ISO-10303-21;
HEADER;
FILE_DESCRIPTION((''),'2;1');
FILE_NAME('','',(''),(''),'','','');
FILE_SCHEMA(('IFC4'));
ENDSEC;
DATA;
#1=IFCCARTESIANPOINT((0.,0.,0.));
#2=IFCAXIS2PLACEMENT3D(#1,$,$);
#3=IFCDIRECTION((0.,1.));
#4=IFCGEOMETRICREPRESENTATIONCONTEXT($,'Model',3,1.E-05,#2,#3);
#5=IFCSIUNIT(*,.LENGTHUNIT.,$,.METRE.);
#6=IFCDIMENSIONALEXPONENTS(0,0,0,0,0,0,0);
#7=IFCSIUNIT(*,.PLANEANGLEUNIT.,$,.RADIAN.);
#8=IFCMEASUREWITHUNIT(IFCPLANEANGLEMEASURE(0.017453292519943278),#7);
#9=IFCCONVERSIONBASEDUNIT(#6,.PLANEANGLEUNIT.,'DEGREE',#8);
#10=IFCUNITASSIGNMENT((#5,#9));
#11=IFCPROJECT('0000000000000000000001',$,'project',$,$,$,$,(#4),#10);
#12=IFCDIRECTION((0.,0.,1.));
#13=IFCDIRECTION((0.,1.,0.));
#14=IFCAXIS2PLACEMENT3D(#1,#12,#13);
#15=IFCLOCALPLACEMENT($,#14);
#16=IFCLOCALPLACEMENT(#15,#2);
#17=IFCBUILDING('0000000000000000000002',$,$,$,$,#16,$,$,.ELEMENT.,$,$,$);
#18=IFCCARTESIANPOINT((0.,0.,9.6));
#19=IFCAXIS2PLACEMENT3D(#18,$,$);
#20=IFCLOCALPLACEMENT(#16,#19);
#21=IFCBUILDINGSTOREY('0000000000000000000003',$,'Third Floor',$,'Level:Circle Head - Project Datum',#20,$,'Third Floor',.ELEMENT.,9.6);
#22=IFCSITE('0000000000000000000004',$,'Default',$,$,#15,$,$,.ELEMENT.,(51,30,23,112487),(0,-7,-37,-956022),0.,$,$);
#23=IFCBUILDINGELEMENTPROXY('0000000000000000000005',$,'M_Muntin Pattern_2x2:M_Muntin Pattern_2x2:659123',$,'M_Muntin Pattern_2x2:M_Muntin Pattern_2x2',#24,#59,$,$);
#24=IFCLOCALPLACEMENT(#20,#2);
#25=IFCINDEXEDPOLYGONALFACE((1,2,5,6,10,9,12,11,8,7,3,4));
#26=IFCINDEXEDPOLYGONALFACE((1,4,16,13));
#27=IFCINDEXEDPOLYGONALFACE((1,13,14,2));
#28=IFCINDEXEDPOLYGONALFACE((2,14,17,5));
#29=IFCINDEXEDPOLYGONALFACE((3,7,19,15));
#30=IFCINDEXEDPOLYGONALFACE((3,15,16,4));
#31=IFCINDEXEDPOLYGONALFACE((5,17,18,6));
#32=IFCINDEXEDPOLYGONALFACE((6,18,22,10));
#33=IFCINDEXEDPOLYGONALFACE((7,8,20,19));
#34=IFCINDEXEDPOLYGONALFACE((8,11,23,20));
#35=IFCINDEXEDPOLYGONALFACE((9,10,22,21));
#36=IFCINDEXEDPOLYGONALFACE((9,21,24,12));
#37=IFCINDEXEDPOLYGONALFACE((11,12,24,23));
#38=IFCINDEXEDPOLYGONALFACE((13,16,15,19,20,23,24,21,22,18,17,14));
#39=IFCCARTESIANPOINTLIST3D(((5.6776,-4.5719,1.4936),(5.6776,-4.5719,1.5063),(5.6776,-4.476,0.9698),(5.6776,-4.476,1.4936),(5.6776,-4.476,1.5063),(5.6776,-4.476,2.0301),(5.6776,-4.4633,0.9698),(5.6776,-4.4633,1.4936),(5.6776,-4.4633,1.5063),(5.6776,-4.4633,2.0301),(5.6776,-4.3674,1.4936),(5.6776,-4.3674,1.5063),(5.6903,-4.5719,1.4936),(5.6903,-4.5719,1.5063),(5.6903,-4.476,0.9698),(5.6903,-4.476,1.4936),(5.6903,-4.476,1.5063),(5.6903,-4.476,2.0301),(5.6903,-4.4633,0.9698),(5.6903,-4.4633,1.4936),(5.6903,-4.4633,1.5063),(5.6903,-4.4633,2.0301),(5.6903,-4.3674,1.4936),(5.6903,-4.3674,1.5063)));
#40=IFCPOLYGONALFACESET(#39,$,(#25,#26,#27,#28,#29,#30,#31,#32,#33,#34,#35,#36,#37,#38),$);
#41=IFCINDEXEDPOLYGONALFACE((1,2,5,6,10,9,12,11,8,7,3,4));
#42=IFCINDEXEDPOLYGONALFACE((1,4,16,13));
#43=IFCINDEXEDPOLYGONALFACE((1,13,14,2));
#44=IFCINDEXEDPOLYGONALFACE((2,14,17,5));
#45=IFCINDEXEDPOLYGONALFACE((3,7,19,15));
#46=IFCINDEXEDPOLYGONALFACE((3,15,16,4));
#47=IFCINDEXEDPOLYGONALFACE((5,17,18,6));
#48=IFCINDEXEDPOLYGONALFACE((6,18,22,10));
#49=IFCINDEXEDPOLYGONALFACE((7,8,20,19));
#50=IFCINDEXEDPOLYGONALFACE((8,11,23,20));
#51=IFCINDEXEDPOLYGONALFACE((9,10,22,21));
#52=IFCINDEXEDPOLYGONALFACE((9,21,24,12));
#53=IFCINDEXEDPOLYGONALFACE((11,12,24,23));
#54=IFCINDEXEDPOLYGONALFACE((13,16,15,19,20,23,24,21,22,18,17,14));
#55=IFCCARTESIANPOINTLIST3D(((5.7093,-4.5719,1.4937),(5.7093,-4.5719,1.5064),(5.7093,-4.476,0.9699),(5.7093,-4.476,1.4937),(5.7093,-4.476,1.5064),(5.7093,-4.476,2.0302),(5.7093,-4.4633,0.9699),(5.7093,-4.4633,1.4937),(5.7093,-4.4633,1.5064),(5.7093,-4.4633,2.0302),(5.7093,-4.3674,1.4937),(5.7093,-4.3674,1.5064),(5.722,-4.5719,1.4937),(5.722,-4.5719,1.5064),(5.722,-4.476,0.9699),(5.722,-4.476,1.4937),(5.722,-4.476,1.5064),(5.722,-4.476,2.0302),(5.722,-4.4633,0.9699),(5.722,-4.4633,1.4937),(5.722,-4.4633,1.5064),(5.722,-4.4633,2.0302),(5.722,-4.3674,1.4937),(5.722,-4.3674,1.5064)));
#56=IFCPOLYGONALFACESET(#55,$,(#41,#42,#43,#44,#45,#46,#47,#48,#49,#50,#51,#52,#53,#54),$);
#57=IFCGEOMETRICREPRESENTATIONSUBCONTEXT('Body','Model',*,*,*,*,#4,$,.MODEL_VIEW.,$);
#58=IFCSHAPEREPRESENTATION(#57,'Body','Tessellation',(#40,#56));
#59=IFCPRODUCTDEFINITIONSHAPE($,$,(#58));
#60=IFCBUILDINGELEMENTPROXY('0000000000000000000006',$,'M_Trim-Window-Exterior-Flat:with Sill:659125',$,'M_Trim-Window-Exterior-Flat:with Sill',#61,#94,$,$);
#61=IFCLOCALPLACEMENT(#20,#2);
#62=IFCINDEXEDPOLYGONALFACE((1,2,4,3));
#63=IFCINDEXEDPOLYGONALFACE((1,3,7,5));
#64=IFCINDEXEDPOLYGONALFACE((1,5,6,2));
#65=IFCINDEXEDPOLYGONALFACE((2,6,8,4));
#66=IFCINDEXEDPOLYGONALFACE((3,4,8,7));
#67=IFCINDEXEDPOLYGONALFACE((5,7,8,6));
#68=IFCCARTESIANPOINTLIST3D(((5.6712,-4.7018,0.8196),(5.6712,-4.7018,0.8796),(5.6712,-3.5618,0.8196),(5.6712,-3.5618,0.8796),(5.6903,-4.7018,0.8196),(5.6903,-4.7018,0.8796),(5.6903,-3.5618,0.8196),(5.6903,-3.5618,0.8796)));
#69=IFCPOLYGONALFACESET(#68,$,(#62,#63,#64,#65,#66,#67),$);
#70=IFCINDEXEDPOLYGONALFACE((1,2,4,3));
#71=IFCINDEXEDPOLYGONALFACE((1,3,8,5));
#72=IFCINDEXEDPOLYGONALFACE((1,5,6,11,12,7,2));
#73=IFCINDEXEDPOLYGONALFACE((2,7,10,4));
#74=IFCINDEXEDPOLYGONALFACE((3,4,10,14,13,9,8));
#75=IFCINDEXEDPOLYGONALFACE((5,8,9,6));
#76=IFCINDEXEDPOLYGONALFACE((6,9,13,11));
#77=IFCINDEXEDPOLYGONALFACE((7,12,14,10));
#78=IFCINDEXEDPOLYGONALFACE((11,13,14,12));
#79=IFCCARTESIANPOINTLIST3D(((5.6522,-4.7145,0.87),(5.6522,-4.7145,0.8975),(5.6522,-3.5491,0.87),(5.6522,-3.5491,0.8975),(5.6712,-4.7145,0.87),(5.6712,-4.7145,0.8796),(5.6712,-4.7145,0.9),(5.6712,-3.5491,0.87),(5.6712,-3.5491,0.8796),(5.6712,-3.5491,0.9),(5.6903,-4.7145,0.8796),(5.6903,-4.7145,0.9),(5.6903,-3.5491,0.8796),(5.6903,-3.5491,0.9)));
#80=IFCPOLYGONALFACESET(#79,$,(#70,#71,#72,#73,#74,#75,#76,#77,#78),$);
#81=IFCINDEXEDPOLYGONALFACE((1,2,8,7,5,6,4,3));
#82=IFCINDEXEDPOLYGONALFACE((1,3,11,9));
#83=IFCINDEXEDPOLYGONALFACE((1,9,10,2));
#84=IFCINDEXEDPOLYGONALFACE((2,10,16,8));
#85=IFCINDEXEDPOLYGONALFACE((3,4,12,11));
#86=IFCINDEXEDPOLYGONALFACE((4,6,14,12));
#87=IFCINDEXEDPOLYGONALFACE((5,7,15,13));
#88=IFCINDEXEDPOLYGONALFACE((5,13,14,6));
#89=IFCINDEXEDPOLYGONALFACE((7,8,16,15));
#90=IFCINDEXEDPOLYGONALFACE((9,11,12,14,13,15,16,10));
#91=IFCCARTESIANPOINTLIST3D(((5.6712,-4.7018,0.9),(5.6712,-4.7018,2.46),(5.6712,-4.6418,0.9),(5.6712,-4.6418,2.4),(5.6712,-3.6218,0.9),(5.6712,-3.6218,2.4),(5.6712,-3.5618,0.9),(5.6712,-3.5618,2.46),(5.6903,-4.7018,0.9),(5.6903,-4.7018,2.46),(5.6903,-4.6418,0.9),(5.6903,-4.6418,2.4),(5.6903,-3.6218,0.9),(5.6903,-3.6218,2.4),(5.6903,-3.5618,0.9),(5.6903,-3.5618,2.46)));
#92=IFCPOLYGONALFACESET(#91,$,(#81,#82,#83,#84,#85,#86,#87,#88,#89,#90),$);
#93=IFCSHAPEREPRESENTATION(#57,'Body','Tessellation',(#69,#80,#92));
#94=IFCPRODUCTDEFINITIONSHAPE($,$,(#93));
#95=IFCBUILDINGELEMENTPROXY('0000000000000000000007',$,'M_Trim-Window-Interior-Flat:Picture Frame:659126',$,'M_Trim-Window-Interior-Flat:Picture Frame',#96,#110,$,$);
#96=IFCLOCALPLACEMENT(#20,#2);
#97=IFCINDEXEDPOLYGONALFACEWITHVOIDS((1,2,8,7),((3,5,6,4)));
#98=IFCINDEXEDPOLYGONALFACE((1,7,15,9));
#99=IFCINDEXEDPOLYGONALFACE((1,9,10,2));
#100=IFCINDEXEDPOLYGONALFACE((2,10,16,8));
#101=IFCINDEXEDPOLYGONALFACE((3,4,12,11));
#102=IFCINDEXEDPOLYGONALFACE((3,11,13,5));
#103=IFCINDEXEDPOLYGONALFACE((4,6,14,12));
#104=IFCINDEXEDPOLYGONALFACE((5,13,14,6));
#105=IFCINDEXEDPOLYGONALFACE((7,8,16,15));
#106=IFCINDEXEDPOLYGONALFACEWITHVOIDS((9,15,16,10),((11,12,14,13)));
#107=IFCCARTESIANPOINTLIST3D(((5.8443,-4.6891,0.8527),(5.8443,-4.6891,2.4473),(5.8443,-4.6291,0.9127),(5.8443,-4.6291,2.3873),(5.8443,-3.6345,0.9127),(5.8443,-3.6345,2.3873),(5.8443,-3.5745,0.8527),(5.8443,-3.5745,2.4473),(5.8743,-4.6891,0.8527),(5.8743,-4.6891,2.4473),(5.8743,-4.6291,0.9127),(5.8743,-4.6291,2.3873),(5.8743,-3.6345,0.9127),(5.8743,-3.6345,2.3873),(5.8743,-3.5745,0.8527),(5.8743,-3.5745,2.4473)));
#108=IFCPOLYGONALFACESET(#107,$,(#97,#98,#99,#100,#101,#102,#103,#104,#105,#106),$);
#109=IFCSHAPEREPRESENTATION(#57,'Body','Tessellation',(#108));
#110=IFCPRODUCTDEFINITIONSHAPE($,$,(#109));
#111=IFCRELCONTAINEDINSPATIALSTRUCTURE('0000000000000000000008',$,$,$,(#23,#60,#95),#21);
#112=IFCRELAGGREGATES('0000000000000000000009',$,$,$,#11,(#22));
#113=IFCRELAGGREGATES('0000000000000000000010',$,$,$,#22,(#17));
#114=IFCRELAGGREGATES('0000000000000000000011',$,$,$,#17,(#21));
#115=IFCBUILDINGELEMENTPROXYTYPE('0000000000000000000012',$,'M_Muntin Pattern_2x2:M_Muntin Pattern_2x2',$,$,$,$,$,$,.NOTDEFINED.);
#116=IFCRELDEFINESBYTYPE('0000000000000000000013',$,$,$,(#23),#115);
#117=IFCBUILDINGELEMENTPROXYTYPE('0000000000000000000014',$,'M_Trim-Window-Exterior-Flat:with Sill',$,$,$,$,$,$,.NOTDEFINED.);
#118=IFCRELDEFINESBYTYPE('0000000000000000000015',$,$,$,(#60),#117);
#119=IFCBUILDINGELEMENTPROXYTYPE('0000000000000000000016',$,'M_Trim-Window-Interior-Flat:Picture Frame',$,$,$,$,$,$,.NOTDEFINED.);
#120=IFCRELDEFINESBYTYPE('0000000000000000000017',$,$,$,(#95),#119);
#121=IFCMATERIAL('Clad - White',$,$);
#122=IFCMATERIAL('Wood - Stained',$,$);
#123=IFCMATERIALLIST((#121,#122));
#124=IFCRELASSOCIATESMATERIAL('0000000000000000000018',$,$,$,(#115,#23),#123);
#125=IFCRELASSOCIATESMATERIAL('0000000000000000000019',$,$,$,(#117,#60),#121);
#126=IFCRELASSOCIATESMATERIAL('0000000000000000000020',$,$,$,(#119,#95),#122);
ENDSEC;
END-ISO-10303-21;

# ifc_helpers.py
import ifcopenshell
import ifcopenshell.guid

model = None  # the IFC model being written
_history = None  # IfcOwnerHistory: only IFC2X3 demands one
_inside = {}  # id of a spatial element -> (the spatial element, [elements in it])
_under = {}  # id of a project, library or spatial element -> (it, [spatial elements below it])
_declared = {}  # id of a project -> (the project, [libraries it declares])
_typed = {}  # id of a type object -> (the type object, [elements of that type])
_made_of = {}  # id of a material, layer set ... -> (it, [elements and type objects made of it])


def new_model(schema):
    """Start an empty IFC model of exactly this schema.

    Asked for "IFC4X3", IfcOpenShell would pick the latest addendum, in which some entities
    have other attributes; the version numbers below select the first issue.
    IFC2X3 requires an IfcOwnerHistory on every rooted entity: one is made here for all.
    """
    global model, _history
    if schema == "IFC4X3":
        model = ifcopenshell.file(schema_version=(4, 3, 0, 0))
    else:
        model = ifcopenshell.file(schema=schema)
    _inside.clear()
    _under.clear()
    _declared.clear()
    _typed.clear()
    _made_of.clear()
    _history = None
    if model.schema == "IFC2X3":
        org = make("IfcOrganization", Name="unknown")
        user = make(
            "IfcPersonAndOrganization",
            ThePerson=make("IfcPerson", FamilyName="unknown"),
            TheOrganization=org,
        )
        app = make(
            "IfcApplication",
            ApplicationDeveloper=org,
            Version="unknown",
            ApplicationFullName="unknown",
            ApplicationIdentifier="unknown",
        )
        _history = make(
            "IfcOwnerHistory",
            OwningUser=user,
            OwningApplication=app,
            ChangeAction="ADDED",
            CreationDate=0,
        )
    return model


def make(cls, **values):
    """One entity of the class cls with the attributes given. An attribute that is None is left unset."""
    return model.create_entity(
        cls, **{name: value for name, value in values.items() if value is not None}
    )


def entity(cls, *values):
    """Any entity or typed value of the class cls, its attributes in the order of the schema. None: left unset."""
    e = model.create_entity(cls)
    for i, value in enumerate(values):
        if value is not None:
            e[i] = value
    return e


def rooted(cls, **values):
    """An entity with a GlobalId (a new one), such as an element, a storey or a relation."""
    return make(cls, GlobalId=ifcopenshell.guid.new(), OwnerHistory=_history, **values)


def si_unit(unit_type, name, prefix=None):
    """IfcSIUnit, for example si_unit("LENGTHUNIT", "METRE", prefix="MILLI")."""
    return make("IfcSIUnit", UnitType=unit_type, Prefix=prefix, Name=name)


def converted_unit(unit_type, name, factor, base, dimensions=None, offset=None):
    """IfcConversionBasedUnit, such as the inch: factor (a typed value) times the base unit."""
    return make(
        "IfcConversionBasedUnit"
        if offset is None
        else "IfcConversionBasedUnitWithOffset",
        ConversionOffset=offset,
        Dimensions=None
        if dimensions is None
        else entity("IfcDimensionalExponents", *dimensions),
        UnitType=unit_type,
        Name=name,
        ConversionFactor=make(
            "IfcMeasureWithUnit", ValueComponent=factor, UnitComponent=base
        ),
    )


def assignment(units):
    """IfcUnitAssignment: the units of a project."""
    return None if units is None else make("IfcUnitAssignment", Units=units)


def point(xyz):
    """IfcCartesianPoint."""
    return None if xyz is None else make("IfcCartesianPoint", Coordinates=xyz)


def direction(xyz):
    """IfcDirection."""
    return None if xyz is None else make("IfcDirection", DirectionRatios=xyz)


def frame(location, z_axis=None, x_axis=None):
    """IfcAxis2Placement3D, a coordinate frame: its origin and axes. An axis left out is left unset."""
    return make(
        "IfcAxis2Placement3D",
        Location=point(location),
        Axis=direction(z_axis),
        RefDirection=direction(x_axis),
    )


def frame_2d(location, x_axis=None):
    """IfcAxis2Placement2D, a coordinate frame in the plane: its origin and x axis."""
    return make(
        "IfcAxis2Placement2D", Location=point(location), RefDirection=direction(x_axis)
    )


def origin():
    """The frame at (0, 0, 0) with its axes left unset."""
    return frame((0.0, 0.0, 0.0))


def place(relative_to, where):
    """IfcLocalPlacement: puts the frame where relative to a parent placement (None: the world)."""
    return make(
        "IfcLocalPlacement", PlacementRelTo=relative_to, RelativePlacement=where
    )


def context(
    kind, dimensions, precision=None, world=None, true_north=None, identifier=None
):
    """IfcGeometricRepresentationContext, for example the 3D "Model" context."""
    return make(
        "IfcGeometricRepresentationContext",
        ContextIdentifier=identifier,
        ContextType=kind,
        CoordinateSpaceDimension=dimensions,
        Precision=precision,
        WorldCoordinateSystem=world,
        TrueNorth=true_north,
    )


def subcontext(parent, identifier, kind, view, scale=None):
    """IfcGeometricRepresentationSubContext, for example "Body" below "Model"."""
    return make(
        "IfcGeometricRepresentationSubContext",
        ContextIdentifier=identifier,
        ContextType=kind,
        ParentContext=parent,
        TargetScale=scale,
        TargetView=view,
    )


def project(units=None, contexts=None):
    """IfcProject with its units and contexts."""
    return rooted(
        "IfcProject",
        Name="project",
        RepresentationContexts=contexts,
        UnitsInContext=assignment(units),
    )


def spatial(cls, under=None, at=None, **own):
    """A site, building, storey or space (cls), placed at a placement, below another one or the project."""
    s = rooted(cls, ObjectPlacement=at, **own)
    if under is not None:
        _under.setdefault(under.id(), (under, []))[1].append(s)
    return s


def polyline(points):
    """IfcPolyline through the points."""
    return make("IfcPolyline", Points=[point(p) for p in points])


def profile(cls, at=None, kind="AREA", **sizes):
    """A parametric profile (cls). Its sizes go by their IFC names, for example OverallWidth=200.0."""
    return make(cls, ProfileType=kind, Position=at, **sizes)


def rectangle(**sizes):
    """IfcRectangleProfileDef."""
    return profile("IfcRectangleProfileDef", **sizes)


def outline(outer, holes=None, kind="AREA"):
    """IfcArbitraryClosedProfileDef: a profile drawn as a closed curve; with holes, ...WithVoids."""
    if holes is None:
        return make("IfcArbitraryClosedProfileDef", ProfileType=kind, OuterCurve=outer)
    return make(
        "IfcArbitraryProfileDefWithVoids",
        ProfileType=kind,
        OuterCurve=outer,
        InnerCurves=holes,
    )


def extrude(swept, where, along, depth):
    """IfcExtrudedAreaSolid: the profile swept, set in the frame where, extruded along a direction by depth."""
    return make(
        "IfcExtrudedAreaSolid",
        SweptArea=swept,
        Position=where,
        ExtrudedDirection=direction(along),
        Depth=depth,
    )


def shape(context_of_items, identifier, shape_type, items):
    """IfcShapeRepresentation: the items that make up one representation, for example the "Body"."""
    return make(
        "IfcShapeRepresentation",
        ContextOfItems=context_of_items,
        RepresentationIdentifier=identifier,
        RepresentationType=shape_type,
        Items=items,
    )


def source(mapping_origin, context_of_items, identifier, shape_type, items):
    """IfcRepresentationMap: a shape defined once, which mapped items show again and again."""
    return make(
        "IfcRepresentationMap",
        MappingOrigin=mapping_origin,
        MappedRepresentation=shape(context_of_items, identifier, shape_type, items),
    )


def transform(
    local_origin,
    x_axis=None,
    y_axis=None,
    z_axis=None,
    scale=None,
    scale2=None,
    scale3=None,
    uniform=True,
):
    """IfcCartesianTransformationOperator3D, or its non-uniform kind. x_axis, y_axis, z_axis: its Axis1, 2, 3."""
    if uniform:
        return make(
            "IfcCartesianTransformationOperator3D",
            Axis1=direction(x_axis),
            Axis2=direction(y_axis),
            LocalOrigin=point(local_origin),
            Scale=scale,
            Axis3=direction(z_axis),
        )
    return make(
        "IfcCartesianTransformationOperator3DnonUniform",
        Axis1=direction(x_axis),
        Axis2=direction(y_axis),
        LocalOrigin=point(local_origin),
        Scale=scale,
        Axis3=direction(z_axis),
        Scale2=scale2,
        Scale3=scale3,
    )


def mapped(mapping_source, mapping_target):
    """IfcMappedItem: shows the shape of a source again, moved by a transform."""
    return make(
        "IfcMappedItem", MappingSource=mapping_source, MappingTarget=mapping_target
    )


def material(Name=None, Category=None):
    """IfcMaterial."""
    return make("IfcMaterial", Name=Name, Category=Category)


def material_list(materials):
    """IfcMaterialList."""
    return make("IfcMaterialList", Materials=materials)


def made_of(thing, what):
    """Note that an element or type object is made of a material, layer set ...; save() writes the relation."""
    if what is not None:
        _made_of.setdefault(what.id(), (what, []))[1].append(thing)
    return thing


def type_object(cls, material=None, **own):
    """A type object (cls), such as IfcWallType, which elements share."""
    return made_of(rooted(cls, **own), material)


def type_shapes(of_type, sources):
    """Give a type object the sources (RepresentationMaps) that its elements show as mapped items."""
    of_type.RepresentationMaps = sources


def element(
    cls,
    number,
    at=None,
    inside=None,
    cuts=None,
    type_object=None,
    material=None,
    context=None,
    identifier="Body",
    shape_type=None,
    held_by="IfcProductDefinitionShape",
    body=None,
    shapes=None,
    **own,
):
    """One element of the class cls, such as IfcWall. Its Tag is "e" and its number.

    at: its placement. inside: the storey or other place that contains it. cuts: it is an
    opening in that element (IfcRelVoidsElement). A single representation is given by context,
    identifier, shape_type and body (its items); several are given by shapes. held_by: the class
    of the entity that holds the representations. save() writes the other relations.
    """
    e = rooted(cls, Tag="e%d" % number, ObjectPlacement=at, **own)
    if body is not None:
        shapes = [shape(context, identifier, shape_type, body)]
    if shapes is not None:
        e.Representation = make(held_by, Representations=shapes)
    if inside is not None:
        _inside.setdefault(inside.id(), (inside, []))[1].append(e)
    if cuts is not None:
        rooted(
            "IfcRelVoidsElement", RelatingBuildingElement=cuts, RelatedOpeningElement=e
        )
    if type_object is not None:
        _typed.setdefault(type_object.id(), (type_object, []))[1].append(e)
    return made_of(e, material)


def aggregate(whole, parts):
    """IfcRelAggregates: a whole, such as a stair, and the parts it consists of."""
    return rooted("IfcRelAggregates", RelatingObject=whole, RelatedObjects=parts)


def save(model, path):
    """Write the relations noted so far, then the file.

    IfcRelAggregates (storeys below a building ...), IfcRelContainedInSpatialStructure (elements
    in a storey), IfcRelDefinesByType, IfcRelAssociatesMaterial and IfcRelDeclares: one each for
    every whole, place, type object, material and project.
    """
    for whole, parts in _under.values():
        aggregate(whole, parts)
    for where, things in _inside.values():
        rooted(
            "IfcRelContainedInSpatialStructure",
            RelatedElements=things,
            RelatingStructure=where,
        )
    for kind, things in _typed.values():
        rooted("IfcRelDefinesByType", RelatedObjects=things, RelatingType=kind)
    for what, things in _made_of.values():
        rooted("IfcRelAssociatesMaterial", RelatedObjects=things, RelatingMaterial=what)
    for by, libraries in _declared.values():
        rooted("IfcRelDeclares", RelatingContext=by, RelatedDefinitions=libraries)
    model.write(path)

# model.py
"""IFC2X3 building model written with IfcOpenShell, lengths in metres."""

from ifc_helpers import new_model, entity, si_unit, converted_unit, direction, frame, frame_2d, origin, place, context, subcontext, project, spatial, polyline, rectangle, outline, extrude, source, transform, mapped, material, material_list, type_object, type_shapes, element, save


model = new_model("IFC2X3")

# Units and contexts
model_context = context("Model", 3, precision=1e-05, world=origin(), true_north=direction((0.0, 1.0)))
body_context = subcontext(model_context, "Body", "Model", "MODEL_VIEW")
ifc_project = project(units=[si_unit("LENGTHUNIT", "METRE"), converted_unit("PLANEANGLEUNIT", "DEGREE", entity("IfcPlaneAngleMeasure", 0.017453292519943278), si_unit("PLANEANGLEUNIT", "RADIAN"), dimensions=[0, 0, 0, 0, 0, 0, 0])], contexts=[model_context])

# Site, building, storey
site_placement = place(None, frame((0.0, 0.0, 0.0), z_axis=(0.0, 0.0, 1.0), x_axis=(0.0, 1.0, 0.0)))
site = spatial("IfcSite", under=ifc_project, at=site_placement, Name="Default", CompositionType="ELEMENT", RefLatitude=(51, 30, 23, 112487), RefLongitude=(0, -7, -37, -956022), RefElevation=0.0)
building_placement = place(site_placement, origin())
building = spatial("IfcBuilding", under=site, at=building_placement, CompositionType="ELEMENT")
storey_placement = place(building_placement, frame((0.0, 0.0, 9.6)))
storey = spatial("IfcBuildingStorey", under=building, at=storey_placement, Name="Third Floor", ObjectType="Level:Circle Head - Project Datum", LongName="Third Floor", CompositionType="ELEMENT", Elevation=9.6)

# Building element proxies
ifc_material_1 = material(Name="Clad - White")
ifc_material_2 = material(Name="Wood - Stained")
ifc_material_list = material_list([ifc_material_1, ifc_material_2])
building_element_proxy_type_1 = type_object("IfcBuildingElementProxyType", Name="M_Muntin Pattern_2x2:M_Muntin Pattern_2x2", PredefinedType="NOTDEFINED", material=ifc_material_list)
shared_shape_1 = source(origin(), body_context, "Body", "SweptSolid", [
    extrude(outline(polyline([(0.0064, -0.0064), (0.5301, -0.0064), (0.5301, 0.0063), (0.0064, 0.0063), (0.0064, 0.1023), (-0.0063, 0.1023), (-0.0063, 0.0063), (-0.5302, 0.0063), (-0.5302, -0.0064), (-0.0063, -0.0064), (-0.0063, -0.1023), (0.0064, -0.1023), (0.0064, -0.0064)])), frame((0.0, 0.0095, 0.5301), z_axis=(0.0, 1.0, 0.0), x_axis=(0.0, 0.0, 1.0)), (0.0, 0.0, 1.0), 0.0127),
    extrude(outline(polyline([(0.0064, -0.0064), (0.5302, -0.0064), (0.5302, 0.0063), (0.0064, 0.0063), (0.0064, 0.1023), (-0.0063, 0.1023), (-0.0063, 0.0063), (-0.5302, 0.0063), (-0.5302, -0.0064), (-0.0063, -0.0064), (-0.0063, -0.1023), (0.0064, -0.1023), (0.0064, -0.0064)])), frame((0.0, -0.0222, 0.5302), z_axis=(0.0, 1.0, 0.0), x_axis=(0.0, 0.0, 1.0)), (0.0, 0.0, 1.0), 0.0127),
])
type_shapes(building_element_proxy_type_1, [shared_shape_1])
proxy_1_placement = place(storey_placement, frame((5.6998, -4.4697, 0.9699), z_axis=(0.0, 0.0, 1.0), x_axis=(0.0, 1.0, 0.0)))
element("IfcBuildingElementProxy", 1, at=proxy_1_placement, inside=storey, type_object=building_element_proxy_type_1, material=ifc_material_list, Name="M_Muntin Pattern_2x2:M_Muntin Pattern_2x2:659123", ObjectType="M_Muntin Pattern_2x2:M_Muntin Pattern_2x2", context=body_context, shape_type="MappedRepresentation", body=[
    mapped(shared_shape_1, transform((0.0, 0.0, 0.0), scale=1.0)),
])
building_element_proxy_type_2 = type_object("IfcBuildingElementProxyType", Name="M_Trim-Window-Exterior-Flat:with Sill", PredefinedType="NOTDEFINED", material=ifc_material_1)
shared_shape_2 = source(origin(), body_context, "Body", "SweptSolid", [
    extrude(rectangle(XDim=1.14, YDim=0.06, at=frame_2d((0.0, 0.0), x_axis=(1.0, 0.0))), frame((0.0, -1.5504, 0.0), z_axis=(0.0, 0.0, 1.0), x_axis=(-1.0, 0.0, 0.0)), (0.0, 0.0, 1.0), 0.019),
    extrude(outline(polyline([(-0.019, -0.0152), (0.0, -0.0152), (0.0, -0.0057), (0.019, -0.0057), (0.019, 0.0148), (0.0, 0.0148), (-0.019, 0.0123), (-0.019, -0.0152)])), frame((-0.5827, -1.5148, 0.019), z_axis=(1.0, 0.0, 0.0), x_axis=(0.0, 0.0, -1.0)), (0.0, 0.0, 1.0), 1.1654),
    extrude(outline(polyline([(-0.795, -0.57), (0.765, -0.57), (0.765, -0.51), (-0.735, -0.51), (-0.735, 0.51), (0.765, 0.51), (0.765, 0.57), (-0.795, 0.57), (-0.795, -0.57)])), frame((0.0, -0.735, 0.0), z_axis=(0.0, 0.0, 1.0), x_axis=(0.0, -1.0, 0.0)), (0.0, 0.0, 1.0), 0.019),
])
type_shapes(building_element_proxy_type_2, [shared_shape_2])
proxy_2_placement = place(storey_placement, frame((5.6903, -4.1318, 2.4), z_axis=(-1.0, 0.0, 0.0), x_axis=(0.0, -1.0, 0.0)))
element("IfcBuildingElementProxy", 2, at=proxy_2_placement, inside=storey, type_object=building_element_proxy_type_2, material=ifc_material_1, Name="M_Trim-Window-Exterior-Flat:with Sill:659125", ObjectType="M_Trim-Window-Exterior-Flat:with Sill", context=body_context, shape_type="MappedRepresentation", body=[
    mapped(shared_shape_2, transform((0.0, 0.0, 0.0), scale=1.0)),
])
building_element_proxy_type_3 = type_object("IfcBuildingElementProxyType", Name="M_Trim-Window-Interior-Flat:Picture Frame", PredefinedType="NOTDEFINED", material=ifc_material_2)
shared_shape_3 = source(origin(), body_context, "Body", "SweptSolid", [
    extrude(outline(polyline([(-0.5573, -0.7973), (0.5573, -0.7973), (0.5573, 0.7973), (-0.5573, 0.7973), (-0.5573, -0.7973)]), holes=[polyline([(-0.4973, -0.7373), (-0.4973, 0.7373), (0.4973, 0.7373), (0.4973, -0.7373), (-0.4973, -0.7373)])]), frame((0.0, -0.75, 0.0), z_axis=(0.0, 0.0, 1.0), x_axis=(-1.0, 0.0, 0.0)), (0.0, 0.0, 1.0), 0.03),
])
type_shapes(building_element_proxy_type_3, [shared_shape_3])
proxy_3_placement = place(storey_placement, frame((5.8443, -4.1318, 2.4), z_axis=(1.0, 0.0, 0.0), x_axis=(0.0, 1.0, 0.0)))
element("IfcBuildingElementProxy", 3, at=proxy_3_placement, inside=storey, type_object=building_element_proxy_type_3, material=ifc_material_2, Name="M_Trim-Window-Interior-Flat:Picture Frame:659126", ObjectType="M_Trim-Window-Interior-Flat:Picture Frame", context=body_context, shape_type="MappedRepresentation", body=[
    mapped(shared_shape_3, transform((0.0, 0.0, 0.0), scale=1.0)),
])

save(model, "model.ifc")
